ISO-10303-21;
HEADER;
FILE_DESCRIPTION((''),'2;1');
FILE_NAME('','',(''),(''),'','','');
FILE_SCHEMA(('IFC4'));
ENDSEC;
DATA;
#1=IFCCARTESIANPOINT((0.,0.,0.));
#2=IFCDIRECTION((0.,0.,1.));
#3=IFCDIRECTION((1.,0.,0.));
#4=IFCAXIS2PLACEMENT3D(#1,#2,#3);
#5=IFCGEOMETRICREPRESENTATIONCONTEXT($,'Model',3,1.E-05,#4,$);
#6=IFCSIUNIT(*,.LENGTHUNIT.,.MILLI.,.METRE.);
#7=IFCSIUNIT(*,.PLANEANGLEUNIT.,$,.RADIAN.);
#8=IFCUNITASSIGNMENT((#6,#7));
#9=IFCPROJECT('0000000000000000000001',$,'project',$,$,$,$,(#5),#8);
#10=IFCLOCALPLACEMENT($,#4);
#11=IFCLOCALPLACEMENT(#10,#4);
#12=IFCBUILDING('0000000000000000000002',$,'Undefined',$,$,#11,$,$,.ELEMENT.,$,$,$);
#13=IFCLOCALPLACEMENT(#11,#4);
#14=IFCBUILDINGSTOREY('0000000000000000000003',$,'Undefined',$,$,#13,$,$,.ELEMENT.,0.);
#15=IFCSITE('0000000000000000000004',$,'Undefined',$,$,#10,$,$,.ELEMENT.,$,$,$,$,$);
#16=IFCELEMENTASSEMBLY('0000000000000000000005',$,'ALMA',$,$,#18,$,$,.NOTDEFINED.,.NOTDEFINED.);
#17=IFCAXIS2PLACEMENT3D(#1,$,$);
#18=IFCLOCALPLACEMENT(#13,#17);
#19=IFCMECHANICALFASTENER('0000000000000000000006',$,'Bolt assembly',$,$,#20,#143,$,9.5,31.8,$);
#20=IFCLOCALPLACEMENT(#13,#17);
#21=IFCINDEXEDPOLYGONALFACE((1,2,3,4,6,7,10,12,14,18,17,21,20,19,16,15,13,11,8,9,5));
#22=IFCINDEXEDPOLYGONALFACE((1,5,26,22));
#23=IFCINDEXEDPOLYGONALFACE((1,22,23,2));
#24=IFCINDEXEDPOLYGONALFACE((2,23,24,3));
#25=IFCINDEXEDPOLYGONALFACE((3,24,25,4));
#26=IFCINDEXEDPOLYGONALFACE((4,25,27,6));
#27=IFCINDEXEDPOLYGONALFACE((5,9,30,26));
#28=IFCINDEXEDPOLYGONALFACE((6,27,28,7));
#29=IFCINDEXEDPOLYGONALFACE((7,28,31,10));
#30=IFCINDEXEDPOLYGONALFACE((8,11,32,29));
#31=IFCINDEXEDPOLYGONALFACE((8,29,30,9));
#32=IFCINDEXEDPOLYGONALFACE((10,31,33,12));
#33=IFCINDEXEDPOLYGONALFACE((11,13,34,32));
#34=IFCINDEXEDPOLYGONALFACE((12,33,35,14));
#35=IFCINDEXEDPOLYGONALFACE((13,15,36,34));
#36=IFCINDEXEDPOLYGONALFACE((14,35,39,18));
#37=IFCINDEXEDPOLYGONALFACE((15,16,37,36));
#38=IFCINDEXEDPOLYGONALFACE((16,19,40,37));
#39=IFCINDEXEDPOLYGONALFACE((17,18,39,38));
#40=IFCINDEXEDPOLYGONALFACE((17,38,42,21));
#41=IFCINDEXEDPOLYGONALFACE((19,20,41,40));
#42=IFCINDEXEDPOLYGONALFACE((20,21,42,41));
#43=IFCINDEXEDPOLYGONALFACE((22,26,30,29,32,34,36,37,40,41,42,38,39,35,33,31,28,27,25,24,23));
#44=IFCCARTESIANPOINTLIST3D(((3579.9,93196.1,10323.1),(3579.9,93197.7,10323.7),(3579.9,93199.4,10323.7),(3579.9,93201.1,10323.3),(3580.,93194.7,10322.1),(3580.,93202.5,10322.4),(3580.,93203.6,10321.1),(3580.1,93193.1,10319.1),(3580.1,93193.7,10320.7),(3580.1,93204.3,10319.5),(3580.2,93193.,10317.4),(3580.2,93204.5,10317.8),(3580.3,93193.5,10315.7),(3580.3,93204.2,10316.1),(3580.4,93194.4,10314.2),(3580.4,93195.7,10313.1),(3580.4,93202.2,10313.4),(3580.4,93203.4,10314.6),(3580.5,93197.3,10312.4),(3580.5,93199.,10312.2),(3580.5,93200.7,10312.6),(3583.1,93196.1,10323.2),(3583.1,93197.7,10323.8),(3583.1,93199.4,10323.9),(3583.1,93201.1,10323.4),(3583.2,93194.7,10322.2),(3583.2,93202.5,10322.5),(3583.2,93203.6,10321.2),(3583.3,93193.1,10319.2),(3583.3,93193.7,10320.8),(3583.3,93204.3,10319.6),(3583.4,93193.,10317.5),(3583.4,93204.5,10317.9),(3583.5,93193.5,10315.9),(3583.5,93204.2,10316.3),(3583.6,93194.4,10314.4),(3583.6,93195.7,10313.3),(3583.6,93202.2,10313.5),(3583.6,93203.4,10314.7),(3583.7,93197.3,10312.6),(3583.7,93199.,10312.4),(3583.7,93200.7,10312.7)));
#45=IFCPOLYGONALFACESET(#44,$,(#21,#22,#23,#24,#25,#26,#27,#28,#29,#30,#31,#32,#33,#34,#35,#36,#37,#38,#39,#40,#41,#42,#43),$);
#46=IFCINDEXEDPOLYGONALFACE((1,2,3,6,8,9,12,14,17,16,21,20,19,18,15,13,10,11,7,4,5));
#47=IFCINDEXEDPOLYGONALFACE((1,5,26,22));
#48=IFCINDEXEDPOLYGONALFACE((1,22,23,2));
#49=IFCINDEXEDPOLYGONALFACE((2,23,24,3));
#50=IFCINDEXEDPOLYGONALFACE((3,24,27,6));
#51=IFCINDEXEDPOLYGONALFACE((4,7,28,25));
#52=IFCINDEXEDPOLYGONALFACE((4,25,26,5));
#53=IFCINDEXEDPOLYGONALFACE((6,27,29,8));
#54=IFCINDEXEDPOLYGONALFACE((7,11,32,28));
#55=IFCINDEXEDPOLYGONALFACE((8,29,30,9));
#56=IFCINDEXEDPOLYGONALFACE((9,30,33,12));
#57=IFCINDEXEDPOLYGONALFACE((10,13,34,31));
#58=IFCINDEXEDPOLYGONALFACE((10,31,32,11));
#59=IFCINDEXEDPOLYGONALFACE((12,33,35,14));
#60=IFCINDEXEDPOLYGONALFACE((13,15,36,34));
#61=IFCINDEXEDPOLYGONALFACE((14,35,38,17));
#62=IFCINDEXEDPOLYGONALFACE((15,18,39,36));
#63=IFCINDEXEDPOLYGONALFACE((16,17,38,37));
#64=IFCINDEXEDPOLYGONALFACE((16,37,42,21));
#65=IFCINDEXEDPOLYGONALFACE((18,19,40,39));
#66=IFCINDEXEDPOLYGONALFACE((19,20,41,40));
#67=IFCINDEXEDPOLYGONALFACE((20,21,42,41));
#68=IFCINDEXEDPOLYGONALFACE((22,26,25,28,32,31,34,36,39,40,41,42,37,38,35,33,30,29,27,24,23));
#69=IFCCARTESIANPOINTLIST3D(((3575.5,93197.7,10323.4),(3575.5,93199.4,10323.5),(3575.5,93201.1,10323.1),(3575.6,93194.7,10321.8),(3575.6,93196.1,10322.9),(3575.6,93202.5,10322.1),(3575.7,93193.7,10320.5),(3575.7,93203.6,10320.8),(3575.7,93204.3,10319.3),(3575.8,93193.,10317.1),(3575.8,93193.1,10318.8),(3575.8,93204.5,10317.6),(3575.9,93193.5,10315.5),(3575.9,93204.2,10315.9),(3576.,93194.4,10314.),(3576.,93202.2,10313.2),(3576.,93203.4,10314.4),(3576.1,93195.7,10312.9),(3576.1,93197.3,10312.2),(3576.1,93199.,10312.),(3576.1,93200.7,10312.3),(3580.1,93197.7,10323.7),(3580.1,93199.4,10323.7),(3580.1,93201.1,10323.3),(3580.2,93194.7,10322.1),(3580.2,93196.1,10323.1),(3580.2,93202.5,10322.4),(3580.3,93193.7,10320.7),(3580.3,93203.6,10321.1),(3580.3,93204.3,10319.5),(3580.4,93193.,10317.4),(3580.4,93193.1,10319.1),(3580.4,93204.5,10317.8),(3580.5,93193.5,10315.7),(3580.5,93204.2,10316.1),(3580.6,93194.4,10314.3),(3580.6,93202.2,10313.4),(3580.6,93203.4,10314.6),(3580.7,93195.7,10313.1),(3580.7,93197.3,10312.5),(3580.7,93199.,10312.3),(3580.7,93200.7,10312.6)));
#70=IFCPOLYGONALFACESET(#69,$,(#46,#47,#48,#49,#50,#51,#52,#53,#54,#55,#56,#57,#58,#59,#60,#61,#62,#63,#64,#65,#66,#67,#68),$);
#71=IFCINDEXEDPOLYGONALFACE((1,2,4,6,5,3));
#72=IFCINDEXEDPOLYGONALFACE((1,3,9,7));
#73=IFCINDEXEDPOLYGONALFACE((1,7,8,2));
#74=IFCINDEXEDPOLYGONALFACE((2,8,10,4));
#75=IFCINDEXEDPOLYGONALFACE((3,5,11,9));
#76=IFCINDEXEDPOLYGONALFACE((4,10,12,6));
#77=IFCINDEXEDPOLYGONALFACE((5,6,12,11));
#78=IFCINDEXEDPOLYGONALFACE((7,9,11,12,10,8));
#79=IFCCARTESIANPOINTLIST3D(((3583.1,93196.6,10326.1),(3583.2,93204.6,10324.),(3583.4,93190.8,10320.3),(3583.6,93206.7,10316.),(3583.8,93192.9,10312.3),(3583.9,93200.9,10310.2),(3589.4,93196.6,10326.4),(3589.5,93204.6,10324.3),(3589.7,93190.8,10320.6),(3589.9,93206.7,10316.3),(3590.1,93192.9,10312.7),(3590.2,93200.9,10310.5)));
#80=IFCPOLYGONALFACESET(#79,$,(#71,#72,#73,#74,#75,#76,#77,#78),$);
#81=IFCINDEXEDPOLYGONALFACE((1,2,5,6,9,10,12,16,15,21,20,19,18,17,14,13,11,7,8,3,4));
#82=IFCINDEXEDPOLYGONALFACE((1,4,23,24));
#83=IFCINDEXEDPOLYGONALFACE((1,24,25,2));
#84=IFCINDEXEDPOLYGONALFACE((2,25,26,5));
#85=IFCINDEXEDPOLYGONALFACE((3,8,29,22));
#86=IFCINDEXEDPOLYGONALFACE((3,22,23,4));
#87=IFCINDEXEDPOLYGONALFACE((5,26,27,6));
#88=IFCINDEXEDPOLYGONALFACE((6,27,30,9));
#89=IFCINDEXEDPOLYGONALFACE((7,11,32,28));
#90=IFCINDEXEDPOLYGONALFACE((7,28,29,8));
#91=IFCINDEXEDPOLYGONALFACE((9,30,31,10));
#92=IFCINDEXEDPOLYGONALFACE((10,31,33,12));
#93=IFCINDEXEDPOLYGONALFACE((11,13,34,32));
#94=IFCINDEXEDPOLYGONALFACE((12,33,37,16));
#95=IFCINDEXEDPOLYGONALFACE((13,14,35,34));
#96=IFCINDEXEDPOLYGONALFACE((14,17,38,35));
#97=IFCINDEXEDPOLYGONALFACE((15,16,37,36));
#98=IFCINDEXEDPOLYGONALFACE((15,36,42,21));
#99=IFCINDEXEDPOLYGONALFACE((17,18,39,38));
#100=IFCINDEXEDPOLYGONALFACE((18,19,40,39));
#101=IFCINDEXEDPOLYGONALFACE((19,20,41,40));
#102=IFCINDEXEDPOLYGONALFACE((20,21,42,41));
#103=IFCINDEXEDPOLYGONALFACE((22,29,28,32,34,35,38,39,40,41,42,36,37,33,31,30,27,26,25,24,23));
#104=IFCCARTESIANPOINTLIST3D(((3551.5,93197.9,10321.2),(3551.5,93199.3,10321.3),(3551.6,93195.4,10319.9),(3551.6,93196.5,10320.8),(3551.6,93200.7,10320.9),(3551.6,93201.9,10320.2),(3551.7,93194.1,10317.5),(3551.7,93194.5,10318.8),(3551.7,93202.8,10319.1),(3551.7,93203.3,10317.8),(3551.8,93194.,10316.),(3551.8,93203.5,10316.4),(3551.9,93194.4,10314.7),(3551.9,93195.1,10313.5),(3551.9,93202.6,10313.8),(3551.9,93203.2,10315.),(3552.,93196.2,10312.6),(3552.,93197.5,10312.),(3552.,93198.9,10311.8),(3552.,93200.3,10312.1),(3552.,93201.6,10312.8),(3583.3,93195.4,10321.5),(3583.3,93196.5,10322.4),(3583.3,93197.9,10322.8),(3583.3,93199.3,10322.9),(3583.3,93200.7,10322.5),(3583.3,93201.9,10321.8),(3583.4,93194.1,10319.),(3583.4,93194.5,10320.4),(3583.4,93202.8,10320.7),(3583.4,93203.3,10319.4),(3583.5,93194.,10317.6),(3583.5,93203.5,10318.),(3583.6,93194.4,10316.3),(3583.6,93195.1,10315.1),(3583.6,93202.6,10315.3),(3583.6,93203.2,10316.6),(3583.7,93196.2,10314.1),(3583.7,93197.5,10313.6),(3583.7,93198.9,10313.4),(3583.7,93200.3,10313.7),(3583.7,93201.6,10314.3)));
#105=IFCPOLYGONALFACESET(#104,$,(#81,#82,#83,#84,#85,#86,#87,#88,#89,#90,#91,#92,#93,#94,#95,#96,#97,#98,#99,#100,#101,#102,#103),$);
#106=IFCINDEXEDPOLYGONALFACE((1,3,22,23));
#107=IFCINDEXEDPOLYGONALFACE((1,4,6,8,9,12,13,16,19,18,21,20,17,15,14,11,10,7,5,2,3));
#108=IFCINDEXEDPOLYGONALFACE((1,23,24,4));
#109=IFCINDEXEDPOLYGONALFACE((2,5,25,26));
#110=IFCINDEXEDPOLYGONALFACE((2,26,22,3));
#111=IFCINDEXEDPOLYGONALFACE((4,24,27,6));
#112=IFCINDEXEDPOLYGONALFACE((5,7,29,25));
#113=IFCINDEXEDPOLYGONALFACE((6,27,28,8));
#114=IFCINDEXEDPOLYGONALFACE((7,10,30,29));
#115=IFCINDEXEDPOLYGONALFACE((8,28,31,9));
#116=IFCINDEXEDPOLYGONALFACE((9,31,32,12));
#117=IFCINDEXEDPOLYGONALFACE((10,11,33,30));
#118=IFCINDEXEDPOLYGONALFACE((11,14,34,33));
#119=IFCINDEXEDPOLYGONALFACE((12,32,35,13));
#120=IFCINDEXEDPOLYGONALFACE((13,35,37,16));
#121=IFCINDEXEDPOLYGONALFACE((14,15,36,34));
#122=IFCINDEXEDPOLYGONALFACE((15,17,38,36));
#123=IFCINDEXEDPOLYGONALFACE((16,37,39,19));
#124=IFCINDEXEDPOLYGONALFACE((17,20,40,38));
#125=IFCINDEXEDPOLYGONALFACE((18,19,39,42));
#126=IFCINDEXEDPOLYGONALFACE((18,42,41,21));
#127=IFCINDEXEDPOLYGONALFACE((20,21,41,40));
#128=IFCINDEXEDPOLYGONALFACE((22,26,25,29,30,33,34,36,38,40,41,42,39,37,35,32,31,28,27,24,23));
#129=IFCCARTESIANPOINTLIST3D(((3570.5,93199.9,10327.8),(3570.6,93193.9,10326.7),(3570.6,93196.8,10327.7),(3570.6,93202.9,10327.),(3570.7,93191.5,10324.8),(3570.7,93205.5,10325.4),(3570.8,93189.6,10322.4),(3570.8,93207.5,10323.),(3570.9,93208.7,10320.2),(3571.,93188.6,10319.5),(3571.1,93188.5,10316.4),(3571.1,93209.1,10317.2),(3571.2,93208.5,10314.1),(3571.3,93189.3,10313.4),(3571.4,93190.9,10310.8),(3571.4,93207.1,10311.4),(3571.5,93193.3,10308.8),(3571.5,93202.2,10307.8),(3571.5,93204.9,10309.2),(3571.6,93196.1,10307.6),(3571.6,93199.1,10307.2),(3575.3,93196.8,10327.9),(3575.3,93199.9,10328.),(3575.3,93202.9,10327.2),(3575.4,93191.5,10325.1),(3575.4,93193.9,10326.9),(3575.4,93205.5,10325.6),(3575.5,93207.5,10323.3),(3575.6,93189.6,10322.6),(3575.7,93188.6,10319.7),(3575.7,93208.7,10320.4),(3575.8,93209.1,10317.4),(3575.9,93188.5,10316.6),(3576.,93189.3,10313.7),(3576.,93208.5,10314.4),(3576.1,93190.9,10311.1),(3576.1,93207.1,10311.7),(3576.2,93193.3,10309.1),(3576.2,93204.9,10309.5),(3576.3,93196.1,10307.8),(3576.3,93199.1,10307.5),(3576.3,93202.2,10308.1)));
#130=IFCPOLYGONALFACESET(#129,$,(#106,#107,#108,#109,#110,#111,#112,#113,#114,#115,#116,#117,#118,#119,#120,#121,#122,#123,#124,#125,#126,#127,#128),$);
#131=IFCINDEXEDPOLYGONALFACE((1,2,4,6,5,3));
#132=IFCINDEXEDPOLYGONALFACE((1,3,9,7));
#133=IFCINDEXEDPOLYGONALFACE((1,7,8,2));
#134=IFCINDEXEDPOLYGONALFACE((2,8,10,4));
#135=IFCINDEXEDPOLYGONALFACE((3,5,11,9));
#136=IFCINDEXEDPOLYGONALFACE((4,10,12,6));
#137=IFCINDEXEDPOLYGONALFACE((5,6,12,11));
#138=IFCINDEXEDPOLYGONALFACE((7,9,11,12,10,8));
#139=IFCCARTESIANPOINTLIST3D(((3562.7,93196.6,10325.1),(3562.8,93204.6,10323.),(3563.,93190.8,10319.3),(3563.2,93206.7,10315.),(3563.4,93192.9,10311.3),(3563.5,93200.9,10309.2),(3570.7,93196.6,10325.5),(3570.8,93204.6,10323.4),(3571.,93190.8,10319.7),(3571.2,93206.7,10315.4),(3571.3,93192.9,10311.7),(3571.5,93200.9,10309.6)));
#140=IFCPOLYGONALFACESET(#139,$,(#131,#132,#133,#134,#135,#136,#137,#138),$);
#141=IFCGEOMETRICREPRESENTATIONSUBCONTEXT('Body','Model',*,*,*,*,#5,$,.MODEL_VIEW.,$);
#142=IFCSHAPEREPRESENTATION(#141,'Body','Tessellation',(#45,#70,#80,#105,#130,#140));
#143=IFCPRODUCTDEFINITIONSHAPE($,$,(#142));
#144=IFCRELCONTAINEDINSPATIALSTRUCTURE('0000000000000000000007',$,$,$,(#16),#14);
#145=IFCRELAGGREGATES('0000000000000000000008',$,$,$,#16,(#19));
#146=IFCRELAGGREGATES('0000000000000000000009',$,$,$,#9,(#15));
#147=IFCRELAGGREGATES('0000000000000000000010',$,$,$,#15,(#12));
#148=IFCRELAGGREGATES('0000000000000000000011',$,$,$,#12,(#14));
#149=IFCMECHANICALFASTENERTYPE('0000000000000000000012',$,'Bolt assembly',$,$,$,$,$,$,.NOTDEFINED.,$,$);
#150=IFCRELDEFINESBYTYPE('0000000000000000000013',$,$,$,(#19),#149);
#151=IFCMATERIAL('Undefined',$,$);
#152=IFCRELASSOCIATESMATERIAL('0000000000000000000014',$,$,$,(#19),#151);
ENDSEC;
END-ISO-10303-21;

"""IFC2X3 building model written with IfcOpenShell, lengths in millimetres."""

from ifc_helpers import new_model, si_unit, frame, origin_with_axes, origin_2d_with_axis, place, context, subcontext, project, spatial, polyline, circle, outline, extrude, source, transform, mapped, material, type_object, element, aggregate, save


model = new_model("IFC2X3")

# Units and contexts
model_context = context("Model", 3, precision=1e-05, world=origin_with_axes())
body_context = subcontext(model_context, "Body", "Model", "MODEL_VIEW")
ifc_project = project(units=[si_unit("LENGTHUNIT", "METRE", prefix="MILLI"), si_unit("PLANEANGLEUNIT", "RADIAN")], contexts=[model_context])

# Site, building, storey
site_placement = place(None, origin_with_axes())
site = spatial("IfcSite", under=ifc_project, at=site_placement, Name="Undefined", CompositionType="ELEMENT")
building_placement = place(site_placement, origin_with_axes())
building = spatial("IfcBuilding", under=site, at=building_placement, Name="Undefined", CompositionType="ELEMENT")
storey_placement = place(building_placement, origin_with_axes())
storey = spatial("IfcBuildingStorey", under=building, at=storey_placement, Name="Undefined", CompositionType="ELEMENT", Elevation=0.0)

# Element assembly
assembly_1_placement = place(storey_placement, origin_with_axes())
assembly_1 = element("IfcElementAssembly", 1, at=assembly_1_placement, inside=storey, Name="ALMA", AssemblyPlace="NOTDEFINED", PredefinedType="NOTDEFINED")

# Shared definitions
ifc_material_1 = material(Name="Undefined")
mechanical_fastener_type = type_object("IfcMechanicalFastenerType", Name="Bolt assembly")

# Mechanical fastener
shared_shape_1 = source(origin_with_axes(), body_context, "Body", "SweptSolid", [
    extrude(circle(Radius=5.8, at=origin_2d_with_axis()), frame((0.0, -7.6, 0.0), z_axis=(0.0, 1.0, 0.0), x_axis=(1.0, 0.0, 0.0)), (0.0, 0.0, 1.0), 3.2),
    extrude(circle(Radius=5.8, at=origin_2d_with_axis()), frame((0.0, -4.6, 0.0), z_axis=(0.0, 1.0, 0.0), x_axis=(1.0, 0.0, 0.0)), (0.0, 0.0, 1.0), 4.6),
    extrude(outline(polyline([(7.1, -4.1), (7.1, 4.1), (0.0, 8.2), (-7.1, 4.1), (-7.1, -4.1), (0.0, -8.2), (7.1, -4.1)])), frame((0.0, -14.0, 0.0), z_axis=(0.0, 1.0, 0.0), x_axis=(1.0, 0.0, 0.0)), (0.0, 0.0, 1.0), 6.3),
    extrude(circle(Radius=4.8, at=origin_2d_with_axis()), frame((0.0, -7.7, 0.0), z_axis=(0.0, 1.0, 0.0), x_axis=(1.0, 0.0, 0.0)), (0.0, 0.0, 1.0), 31.8),
    extrude(circle(Radius=10.3, at=origin_2d_with_axis()), frame((0.0, 0.0, 0.0), z_axis=(0.0, 1.0, 0.0), x_axis=(1.0, 0.0, 0.0)), (0.0, 0.0, 1.0), 4.8),
    extrude(outline(polyline([(7.1, -4.1), (7.1, 4.1), (0.0, 8.2), (-7.1, 4.1), (-7.1, -4.1), (0.0, -8.2), (7.1, -4.1)])), frame((0.0, 4.8, 0.0), z_axis=(0.0, 1.0, 0.0), x_axis=(1.0, 0.0, 0.0)), (0.0, 0.0, 1.0), 7.9),
])
mechanical_fastener_1_placement = place(assembly_1_placement, frame((3575.8, 93198.8, 10317.8), z_axis=(0.035282, -0.707107, -0.706226), x_axis=(-0.035282, -0.707107, 0.706226)))
mechanical_fastener_1 = element("IfcMechanicalFastener", 2, at=mechanical_fastener_1_placement, type_object=mechanical_fastener_type, material=ifc_material_1, Name="Bolt assembly", NominalDiameter=9.5, NominalLength=31.8, context=body_context, shape_type="MappedRepresentation", body=[
    mapped(shared_shape_1, transform((0.0, 0.0, 0.0))),
])

aggregate(assembly_1, [mechanical_fastener_1])

save(model, "model.ifc")
